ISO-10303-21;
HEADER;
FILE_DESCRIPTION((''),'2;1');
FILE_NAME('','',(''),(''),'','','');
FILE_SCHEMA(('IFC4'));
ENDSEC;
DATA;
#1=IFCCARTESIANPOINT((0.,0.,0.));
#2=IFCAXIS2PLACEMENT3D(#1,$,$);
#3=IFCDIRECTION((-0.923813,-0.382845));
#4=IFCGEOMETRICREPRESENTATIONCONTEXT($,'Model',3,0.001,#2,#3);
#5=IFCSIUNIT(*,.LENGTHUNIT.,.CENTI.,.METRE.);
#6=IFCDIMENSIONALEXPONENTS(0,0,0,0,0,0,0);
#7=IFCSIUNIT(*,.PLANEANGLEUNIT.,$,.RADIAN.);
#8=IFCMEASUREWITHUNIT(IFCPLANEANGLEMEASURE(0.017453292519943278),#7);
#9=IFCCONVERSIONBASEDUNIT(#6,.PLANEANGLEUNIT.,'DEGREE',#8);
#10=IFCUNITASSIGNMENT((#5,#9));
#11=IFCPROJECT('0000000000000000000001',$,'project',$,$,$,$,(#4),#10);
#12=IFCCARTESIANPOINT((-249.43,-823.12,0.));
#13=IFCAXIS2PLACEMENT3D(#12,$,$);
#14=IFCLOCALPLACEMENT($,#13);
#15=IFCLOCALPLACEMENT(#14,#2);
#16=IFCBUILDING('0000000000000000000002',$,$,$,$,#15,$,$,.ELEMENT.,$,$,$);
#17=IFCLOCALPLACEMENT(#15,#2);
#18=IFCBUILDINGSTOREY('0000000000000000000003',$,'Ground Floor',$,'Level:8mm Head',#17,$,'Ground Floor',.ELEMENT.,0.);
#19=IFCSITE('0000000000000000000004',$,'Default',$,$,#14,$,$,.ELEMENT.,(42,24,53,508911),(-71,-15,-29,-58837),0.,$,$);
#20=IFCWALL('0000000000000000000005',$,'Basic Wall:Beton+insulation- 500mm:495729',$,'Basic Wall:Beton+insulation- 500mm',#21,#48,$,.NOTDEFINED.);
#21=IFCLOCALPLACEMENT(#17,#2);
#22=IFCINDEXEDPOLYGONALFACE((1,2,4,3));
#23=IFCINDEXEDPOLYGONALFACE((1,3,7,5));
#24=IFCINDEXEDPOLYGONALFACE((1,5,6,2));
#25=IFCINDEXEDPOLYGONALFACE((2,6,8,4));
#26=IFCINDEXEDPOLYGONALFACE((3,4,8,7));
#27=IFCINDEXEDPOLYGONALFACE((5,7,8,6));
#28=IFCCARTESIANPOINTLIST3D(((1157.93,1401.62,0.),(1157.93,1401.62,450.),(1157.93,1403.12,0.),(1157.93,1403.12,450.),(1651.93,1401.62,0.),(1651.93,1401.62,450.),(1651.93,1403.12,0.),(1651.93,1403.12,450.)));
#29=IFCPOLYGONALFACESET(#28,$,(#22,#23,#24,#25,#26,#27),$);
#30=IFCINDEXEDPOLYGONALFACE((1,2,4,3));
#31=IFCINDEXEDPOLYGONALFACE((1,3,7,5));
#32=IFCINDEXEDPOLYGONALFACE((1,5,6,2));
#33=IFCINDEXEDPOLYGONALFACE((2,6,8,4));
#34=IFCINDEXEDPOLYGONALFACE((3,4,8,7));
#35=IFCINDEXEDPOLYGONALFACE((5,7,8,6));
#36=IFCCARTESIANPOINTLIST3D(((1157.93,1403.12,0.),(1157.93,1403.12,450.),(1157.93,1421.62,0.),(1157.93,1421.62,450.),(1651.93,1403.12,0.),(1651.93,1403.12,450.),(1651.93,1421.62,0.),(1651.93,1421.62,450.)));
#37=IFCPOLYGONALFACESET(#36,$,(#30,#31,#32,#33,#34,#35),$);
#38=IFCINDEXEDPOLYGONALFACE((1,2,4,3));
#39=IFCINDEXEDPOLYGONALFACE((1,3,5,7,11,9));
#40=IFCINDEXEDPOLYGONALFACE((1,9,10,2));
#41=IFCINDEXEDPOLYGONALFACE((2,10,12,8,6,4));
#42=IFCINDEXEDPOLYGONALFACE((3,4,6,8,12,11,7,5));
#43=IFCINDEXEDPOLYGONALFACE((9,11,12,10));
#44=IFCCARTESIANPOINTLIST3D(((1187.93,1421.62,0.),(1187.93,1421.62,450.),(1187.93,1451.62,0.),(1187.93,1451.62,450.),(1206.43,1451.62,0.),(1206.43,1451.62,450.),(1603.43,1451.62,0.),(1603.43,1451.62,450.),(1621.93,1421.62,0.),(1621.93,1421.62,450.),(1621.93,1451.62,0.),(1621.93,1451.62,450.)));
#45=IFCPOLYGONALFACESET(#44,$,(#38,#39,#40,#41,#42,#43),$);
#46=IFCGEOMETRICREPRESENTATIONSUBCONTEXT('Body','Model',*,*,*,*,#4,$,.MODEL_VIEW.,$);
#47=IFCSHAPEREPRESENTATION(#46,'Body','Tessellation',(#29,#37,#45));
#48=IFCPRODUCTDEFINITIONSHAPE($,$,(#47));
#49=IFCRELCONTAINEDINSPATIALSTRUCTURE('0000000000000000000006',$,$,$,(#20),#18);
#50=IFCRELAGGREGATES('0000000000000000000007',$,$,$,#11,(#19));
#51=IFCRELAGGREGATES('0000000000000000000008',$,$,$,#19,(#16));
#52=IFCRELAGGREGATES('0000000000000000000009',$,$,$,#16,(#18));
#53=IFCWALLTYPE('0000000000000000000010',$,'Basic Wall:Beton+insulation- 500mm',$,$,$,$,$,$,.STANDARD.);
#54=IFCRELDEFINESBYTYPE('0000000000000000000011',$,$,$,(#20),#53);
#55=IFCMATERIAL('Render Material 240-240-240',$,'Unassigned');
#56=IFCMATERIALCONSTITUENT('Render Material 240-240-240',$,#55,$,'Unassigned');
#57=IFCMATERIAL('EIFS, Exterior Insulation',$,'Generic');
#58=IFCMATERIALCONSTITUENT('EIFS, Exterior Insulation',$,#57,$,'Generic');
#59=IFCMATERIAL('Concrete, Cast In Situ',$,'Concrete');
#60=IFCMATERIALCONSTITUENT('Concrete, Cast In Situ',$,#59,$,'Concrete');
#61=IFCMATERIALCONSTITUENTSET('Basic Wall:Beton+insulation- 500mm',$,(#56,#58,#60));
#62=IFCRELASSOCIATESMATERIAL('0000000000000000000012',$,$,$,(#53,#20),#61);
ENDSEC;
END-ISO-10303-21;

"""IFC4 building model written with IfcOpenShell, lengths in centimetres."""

from ifc_helpers import new_model, entity, si_unit, converted_unit, direction, frame, origin, place, context, subcontext, project, spatial, indexed_curve, outline, extrude, material, constituent, constituent_set, type_object, element, save


model = new_model("IFC4")

# Units and contexts
model_context = context("Model", 3, precision=0.001, world=origin(), true_north=direction((-0.923813, -0.382845)))
body_context = subcontext(model_context, "Body", "Model", "MODEL_VIEW")
ifc_project = project(units=[si_unit("LENGTHUNIT", "METRE", prefix="CENTI"), converted_unit("PLANEANGLEUNIT", "DEGREE", entity("IfcPlaneAngleMeasure", 0.017453292519943278), si_unit("PLANEANGLEUNIT", "RADIAN"), dimensions=[0, 0, 0, 0, 0, 0, 0])], contexts=[model_context])

# Site, building, storey
site_placement = place(None, frame((-249.43, -823.12, 0.0)))
site = spatial("IfcSite", under=ifc_project, at=site_placement, Name="Default", CompositionType="ELEMENT", RefLatitude=(42, 24, 53, 508911), RefLongitude=(-71, -15, -29, -58837), RefElevation=0.0)
building_placement = place(site_placement, origin())
building = spatial("IfcBuilding", under=site, at=building_placement, CompositionType="ELEMENT")
storey_placement = place(building_placement, origin())
storey = spatial("IfcBuildingStorey", under=building, at=storey_placement, Name="Ground Floor", ObjectType="Level:8mm Head", LongName="Ground Floor", CompositionType="ELEMENT", Elevation=0.0)

# Shared definitions
ifc_material_1 = material(Name="Concrete, Cast In Situ", Category="Concrete")
ifc_material_2 = material(Name="Render Material 240-240-240", Category="Unassigned")
ifc_material_3 = material(Name="EIFS, Exterior Insulation", Category="Generic")

# Wall
ifc_constituent_1 = constituent(ifc_material_2, Name="Render Material 240-240-240", Category="Unassigned")
ifc_constituent_2 = constituent(ifc_material_3, Name="EIFS, Exterior Insulation", Category="Generic")
ifc_constituent_3 = constituent(ifc_material_1, Name="Concrete, Cast In Situ", Category="Concrete")
ifc_constituent_set_1 = constituent_set(constituents=[ifc_constituent_1, ifc_constituent_2, ifc_constituent_3], Name="Basic Wall:Beton+insulation- 500mm")
wall_type_1 = type_object("IfcWallType", Name="Basic Wall:Beton+insulation- 500mm", PredefinedType="STANDARD", material=ifc_constituent_set_1)
wall_1_placement = place(storey_placement, frame((1187.93, 1426.62, 0.0)))
element("IfcWall", 1, at=wall_1_placement, inside=storey, type_object=wall_type_1, material=ifc_constituent_set_1, Name="Basic Wall:Beton+insulation- 500mm:495729", ObjectType="Basic Wall:Beton+insulation- 500mm", PredefinedType="NOTDEFINED", context=body_context, shape_type="SweptSolid", body=[
    extrude(outline(indexed_curve([(-0.75, -247.0), (0.75, -247.0), (0.75, 247.0), (-0.75, 247.0), (-0.75, -247.0)], self_intersect=False)), frame((217.0, -24.25, 0.0), z_axis=(0.0, 0.0, 1.0), x_axis=(0.0, 1.0, 0.0)), (0.0, 0.0, 1.0), 450.0),
    extrude(outline(indexed_curve([(-9.25, -247.0), (9.25, -247.0), (9.25, 247.0), (-9.25, 247.0), (-9.25, -247.0)], self_intersect=False)), frame((217.0, -14.25, 0.0), z_axis=(0.0, 0.0, 1.0), x_axis=(0.0, -1.0, 0.0)), (0.0, 0.0, 1.0), 450.0),
    extrude(outline(indexed_curve([(-20.0, -217.0), (10.0, -217.0), (10.0, -198.5), (10.0, 198.5), (10.0, 217.0), (-20.0, 217.0), (-20.0, -217.0)], self_intersect=False)), frame((217.0, 15.0, 0.0), z_axis=(0.0, 0.0, 1.0), x_axis=(0.0, 1.0, 0.0)), (0.0, 0.0, 1.0), 450.0),
])

save(model, "model.ifc")
